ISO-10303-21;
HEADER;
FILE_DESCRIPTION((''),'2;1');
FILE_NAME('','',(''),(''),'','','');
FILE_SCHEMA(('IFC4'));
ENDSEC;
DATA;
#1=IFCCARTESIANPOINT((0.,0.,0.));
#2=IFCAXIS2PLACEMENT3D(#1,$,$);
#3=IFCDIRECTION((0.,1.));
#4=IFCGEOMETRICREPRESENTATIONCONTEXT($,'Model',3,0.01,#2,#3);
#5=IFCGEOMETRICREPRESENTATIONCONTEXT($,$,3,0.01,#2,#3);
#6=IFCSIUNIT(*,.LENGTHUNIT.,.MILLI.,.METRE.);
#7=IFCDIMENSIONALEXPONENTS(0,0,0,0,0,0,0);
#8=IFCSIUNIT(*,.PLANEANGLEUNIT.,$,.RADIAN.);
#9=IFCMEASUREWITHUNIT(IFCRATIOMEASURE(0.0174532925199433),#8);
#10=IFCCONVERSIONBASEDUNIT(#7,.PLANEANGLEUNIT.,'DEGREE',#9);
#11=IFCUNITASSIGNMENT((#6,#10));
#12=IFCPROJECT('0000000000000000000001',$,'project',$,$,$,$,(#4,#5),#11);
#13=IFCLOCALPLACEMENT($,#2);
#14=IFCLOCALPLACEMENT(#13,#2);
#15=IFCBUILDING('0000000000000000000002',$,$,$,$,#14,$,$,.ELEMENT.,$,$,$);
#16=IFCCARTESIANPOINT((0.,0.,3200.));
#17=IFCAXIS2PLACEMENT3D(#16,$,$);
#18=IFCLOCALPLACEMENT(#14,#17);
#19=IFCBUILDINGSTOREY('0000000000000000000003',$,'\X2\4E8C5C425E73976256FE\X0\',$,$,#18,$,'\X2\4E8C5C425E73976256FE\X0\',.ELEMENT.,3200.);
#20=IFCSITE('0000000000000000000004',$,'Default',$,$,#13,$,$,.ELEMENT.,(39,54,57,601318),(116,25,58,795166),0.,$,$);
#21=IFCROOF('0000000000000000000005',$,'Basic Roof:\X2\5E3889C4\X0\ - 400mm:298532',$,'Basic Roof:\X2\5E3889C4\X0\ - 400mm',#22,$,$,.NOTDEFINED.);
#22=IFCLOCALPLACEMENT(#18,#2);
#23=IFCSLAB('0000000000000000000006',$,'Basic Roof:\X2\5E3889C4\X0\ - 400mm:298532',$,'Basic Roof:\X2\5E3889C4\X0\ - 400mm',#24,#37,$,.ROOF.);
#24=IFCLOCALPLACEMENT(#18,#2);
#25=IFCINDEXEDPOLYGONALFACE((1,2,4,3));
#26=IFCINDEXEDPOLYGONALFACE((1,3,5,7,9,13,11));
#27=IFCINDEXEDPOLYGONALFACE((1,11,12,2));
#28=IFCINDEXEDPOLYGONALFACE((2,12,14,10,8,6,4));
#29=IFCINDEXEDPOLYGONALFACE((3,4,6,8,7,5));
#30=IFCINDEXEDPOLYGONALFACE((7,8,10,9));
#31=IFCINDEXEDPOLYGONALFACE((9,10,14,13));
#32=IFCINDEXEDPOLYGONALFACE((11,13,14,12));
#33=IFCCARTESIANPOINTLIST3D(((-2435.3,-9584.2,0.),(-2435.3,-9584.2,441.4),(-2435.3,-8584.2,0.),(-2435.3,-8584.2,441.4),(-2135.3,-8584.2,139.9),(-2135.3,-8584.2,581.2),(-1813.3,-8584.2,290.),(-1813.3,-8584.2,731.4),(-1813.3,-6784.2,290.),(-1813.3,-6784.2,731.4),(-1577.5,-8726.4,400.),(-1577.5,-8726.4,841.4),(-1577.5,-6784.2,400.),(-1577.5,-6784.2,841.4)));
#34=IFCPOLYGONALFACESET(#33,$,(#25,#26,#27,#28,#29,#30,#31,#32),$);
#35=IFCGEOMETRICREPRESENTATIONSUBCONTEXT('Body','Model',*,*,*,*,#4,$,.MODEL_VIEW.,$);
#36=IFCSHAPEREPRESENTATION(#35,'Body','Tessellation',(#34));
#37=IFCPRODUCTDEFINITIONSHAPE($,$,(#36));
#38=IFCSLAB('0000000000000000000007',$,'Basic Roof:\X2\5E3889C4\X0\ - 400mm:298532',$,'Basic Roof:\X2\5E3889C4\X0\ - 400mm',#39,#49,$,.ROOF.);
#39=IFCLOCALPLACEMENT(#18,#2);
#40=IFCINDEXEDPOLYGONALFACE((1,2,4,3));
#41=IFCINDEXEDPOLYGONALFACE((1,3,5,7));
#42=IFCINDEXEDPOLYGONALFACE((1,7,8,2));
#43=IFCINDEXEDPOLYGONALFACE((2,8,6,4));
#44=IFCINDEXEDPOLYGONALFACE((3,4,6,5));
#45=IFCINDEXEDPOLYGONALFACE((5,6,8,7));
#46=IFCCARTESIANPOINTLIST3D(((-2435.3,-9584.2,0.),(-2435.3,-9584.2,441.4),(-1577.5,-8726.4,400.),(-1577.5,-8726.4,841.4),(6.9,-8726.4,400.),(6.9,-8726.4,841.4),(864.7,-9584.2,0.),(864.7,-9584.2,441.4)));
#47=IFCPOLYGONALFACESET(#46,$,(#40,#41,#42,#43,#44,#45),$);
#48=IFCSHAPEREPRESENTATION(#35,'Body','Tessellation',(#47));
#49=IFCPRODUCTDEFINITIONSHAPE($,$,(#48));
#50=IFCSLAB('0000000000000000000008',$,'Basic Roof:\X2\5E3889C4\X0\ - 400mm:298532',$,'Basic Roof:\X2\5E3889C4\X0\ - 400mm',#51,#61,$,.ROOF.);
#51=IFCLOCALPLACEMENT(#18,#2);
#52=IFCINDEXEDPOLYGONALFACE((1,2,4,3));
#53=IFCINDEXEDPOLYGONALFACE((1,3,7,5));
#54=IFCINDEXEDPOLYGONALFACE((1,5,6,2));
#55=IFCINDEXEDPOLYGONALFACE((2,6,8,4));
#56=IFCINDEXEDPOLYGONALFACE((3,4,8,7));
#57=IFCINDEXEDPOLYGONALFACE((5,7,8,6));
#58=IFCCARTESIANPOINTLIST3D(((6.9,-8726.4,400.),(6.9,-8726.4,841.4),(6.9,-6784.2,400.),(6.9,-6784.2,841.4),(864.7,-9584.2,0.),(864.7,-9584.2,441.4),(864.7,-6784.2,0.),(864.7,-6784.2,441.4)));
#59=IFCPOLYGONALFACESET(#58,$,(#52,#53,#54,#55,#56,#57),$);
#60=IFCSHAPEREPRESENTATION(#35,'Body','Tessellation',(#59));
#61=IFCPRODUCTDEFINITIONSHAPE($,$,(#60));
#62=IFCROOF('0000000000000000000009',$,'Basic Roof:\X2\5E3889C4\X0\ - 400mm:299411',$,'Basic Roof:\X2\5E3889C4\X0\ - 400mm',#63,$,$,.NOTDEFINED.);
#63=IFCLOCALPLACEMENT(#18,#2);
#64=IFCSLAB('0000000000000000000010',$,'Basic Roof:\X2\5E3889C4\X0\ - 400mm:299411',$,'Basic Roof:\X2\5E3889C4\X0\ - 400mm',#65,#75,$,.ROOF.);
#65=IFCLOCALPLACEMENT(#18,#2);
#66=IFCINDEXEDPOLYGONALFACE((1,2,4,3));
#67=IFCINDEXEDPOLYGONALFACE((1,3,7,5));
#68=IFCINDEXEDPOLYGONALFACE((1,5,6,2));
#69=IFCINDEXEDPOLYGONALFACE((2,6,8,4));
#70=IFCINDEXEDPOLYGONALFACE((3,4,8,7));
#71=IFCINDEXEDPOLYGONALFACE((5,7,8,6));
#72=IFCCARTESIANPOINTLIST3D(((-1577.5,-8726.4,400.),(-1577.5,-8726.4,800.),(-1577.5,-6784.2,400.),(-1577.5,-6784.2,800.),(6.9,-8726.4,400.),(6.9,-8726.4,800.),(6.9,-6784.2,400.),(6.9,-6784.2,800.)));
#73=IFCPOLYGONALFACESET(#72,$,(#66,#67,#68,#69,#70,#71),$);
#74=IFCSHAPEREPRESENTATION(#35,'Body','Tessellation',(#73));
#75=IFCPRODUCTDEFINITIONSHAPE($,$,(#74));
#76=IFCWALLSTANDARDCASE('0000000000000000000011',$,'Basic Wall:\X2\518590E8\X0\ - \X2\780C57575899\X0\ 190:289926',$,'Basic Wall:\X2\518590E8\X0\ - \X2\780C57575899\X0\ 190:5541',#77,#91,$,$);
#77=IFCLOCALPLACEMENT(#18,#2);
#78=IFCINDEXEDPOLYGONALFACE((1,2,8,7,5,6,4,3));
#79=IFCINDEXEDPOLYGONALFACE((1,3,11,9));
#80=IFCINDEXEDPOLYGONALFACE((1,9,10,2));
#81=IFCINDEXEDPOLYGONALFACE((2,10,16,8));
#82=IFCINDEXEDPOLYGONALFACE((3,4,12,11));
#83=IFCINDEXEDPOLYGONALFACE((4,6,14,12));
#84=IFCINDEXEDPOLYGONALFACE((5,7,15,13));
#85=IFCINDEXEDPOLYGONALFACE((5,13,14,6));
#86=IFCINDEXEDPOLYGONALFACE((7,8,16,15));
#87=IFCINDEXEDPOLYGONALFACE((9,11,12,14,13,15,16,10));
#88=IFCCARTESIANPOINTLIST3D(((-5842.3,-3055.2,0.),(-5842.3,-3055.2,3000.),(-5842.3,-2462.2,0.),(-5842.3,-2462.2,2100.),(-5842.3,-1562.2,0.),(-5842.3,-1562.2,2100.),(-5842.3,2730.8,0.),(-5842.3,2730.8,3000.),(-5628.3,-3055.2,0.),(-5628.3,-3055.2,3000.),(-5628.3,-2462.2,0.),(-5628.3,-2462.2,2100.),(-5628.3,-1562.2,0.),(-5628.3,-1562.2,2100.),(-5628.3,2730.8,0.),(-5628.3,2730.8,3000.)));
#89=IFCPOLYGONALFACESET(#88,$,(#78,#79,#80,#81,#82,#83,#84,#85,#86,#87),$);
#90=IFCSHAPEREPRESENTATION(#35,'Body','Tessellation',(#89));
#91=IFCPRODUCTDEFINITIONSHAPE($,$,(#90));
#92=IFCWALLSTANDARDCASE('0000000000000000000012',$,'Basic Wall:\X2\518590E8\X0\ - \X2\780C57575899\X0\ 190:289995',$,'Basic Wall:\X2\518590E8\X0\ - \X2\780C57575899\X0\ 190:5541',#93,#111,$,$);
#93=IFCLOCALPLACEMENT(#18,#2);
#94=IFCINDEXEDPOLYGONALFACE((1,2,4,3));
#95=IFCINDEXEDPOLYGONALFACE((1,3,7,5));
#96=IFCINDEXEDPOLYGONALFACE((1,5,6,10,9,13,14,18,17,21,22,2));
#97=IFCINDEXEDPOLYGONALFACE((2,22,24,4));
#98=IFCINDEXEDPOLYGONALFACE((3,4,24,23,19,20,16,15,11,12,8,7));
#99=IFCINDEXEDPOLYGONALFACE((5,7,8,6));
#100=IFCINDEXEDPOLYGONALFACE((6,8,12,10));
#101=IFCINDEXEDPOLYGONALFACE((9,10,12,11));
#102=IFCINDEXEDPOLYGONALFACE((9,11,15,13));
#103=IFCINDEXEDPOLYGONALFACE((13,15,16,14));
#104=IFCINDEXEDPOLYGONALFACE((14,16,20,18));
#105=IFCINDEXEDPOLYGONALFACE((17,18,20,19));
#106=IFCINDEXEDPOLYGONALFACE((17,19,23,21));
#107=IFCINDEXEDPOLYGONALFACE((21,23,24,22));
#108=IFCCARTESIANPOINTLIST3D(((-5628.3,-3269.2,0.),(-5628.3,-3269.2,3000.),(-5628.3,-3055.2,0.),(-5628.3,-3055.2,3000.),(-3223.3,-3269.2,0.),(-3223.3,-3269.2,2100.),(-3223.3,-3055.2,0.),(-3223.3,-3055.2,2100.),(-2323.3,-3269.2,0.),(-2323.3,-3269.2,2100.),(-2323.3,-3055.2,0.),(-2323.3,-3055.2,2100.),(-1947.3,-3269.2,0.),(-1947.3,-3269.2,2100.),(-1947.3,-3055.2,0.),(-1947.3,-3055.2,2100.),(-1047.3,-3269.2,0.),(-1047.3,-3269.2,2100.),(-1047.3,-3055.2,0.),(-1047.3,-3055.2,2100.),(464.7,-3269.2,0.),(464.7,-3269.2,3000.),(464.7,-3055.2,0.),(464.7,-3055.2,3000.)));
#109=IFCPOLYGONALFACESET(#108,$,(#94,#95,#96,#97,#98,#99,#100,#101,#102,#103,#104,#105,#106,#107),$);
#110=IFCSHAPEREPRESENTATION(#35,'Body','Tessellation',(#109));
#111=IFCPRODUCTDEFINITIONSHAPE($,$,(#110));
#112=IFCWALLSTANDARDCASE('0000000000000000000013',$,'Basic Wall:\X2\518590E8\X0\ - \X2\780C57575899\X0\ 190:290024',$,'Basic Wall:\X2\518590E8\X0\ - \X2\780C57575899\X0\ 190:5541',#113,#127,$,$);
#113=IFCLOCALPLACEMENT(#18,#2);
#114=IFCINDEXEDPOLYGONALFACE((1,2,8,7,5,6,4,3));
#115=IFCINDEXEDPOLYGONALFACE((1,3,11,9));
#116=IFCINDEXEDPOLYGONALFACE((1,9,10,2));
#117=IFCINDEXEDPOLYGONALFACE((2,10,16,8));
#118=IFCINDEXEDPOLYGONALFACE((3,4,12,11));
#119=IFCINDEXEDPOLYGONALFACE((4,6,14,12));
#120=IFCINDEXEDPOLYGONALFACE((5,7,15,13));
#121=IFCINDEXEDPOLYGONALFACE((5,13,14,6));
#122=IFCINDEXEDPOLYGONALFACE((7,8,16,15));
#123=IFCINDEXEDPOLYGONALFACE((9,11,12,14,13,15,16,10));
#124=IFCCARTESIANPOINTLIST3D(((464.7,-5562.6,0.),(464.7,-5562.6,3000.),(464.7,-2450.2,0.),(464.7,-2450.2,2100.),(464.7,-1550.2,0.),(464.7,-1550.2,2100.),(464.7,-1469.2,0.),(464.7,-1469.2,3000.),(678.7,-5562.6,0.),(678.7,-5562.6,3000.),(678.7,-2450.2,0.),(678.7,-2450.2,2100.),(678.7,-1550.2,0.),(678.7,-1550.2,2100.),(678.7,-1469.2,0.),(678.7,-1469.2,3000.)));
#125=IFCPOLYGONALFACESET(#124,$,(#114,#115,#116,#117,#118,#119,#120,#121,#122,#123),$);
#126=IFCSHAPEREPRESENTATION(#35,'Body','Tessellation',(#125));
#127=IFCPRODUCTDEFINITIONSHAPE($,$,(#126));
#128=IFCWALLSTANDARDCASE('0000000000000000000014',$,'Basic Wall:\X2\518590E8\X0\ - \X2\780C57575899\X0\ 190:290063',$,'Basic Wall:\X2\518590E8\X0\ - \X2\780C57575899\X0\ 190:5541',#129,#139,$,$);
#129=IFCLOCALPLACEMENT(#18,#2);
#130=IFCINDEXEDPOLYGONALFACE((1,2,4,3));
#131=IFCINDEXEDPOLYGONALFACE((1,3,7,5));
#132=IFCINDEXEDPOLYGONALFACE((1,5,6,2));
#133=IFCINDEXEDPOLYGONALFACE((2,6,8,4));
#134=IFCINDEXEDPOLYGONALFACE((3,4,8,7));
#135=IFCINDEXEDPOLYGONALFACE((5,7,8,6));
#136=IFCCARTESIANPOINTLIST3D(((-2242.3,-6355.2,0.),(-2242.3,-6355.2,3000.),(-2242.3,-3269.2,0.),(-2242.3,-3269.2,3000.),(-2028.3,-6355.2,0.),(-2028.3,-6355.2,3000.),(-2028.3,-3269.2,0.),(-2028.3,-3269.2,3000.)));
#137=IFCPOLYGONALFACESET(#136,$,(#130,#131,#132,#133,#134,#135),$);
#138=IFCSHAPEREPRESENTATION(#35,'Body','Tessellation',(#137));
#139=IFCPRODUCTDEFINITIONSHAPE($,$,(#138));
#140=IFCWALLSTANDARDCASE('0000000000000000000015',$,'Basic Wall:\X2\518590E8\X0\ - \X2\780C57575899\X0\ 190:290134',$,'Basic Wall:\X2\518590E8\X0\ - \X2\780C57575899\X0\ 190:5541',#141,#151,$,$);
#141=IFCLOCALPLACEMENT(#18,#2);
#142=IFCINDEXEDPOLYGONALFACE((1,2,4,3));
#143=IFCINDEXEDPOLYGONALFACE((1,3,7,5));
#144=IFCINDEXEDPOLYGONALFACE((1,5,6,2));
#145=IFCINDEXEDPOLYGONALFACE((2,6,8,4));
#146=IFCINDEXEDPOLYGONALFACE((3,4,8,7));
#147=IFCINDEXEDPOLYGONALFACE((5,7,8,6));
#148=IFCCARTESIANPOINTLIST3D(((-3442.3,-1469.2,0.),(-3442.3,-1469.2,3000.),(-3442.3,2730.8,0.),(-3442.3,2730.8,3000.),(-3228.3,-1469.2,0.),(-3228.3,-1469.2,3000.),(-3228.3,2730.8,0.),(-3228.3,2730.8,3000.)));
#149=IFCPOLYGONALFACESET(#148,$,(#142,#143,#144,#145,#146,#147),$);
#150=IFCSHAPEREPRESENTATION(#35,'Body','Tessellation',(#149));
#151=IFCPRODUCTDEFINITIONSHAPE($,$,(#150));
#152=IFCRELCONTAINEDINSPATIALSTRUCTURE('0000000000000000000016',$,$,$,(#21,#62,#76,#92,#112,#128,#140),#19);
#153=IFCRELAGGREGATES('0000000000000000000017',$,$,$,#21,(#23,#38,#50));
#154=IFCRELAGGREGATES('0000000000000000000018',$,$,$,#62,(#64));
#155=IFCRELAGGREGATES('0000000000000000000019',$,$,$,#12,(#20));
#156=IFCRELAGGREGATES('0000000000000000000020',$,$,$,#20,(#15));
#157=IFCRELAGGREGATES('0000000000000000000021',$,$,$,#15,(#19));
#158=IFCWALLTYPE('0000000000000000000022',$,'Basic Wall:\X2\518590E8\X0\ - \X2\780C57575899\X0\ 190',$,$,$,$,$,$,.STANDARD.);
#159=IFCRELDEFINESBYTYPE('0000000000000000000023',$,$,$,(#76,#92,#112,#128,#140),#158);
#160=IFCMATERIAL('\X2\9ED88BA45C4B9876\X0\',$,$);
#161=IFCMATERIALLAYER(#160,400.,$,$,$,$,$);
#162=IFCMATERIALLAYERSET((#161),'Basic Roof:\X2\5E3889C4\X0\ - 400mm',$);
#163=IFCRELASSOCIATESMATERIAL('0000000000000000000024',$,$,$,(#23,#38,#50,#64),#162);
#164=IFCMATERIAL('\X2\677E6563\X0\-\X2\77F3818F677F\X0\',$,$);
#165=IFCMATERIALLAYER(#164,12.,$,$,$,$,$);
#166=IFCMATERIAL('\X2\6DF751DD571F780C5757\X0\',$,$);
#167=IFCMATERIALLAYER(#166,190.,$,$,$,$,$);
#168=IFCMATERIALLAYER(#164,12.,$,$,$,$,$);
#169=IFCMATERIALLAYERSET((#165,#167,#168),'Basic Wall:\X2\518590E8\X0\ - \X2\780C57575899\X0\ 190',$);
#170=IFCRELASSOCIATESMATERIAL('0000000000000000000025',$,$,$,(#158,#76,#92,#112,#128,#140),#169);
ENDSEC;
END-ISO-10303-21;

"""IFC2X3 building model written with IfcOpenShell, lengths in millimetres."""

from ifc_helpers import new_model, entity, si_unit, converted_unit, direction, frame, frame_2d, origin, place, context, subcontext, project, spatial, polyline, rectangle, outline, extrude, material, layer, layer_set, layer_usage, type_object, element, aggregate, save


model = new_model("IFC2X3")

# Units and contexts
model_context = context("Model", 3, precision=0.01, world=origin(), true_north=direction((0.0, 1.0)))
context_of_model = context(None, 3, precision=0.01, world=origin(), true_north=direction((0.0, 1.0)))
body_context = subcontext(model_context, "Body", "Model", "MODEL_VIEW")
ifc_project = project(units=[si_unit("LENGTHUNIT", "METRE", prefix="MILLI"), converted_unit("PLANEANGLEUNIT", "DEGREE", entity("IfcRatioMeasure", 0.0174532925199433), si_unit("PLANEANGLEUNIT", "RADIAN"), dimensions=[0, 0, 0, 0, 0, 0, 0])], contexts=[model_context, context_of_model])

# Site, building, storey
site_placement = place(None, origin())
site = spatial("IfcSite", under=ifc_project, at=site_placement, Name="Default", CompositionType="ELEMENT", RefLatitude=(39, 54, 57, 601318), RefLongitude=(116, 25, 58, 795166), RefElevation=0.0)
building_placement = place(site_placement, origin())
building = spatial("IfcBuilding", under=site, at=building_placement, CompositionType="ELEMENT")
storey_placement = place(building_placement, frame((0.0, 0.0, 3200.0)))
storey = spatial("IfcBuildingStorey", under=building, at=storey_placement, Name="二层平面图", LongName="二层平面图", CompositionType="ELEMENT", Elevation=3200.0)

# Roof, slabs
roof_1_placement = place(storey_placement, frame((-2435.3, -9584.2, 0.0)))
roof_1 = element("IfcRoof", 1, at=roof_1_placement, inside=storey, Name="Basic Roof:常规 - 400mm:298532", ObjectType="Basic Roof:常规 - 400mm", ShapeType="NOTDEFINED")
ifc_material_1 = material(Name="默认屋顶")
ifc_layer_1 = layer(ifc_material_1, 400.0)
ifc_layer_set_1 = layer_set([ifc_layer_1], Name="Basic Roof:常规 - 400mm")
slab_1_placement = place(roof_1_placement, origin())
slab_1 = element("IfcSlab", 2, at=slab_1_placement, material=ifc_layer_set_1, Name="Basic Roof:常规 - 400mm:298532", ObjectType="Basic Roof:常规 - 400mm", PredefinedType="ROOF", context=body_context, shape_type="SweptSolid", body=[
    extrude(outline(polyline([(-473.2, -400.0), (-473.2, -1400.0), (473.2, -542.2), (473.2, 1400.0), (213.1, 1400.0), (213.1, -400.0), (-142.2, -400.0), (-473.2, -400.0)])), frame((428.9, 1400.0, 200.0), z_axis=(-0.422618, 0.0, 0.906308), x_axis=(0.906308, 0.0, 0.422618)), (0.422618, 0.0, 0.906308), 441.4),
])
slab_2_placement = place(roof_1_placement, origin())
slab_2 = element("IfcSlab", 3, at=slab_2_placement, material=ifc_layer_set_1, Name="Basic Roof:常规 - 400mm:298532", ObjectType="Basic Roof:常规 - 400mm", PredefinedType="ROOF", context=body_context, shape_type="SweptSolid", body=[
    extrude(outline(polyline([(1650.0, -473.2), (792.2, 473.2), (-792.2, 473.2), (-1650.0, -473.2), (1650.0, -473.2)])), frame((1650.0, 428.9, 200.0), z_axis=(0.0, -0.422618, 0.906308), x_axis=(1.0, 0.0, 0.0)), (0.0, 0.422618, 0.906308), 441.4),
])
slab_3_placement = place(roof_1_placement, origin())
slab_3 = element("IfcSlab", 4, at=slab_3_placement, material=ifc_layer_set_1, Name="Basic Roof:常规 - 400mm:298532", ObjectType="Basic Roof:常规 - 400mm", PredefinedType="ROOF", context=body_context, shape_type="SweptSolid", body=[
    extrude(outline(polyline([(473.2, 1400.0), (-473.2, 1400.0), (-473.2, -542.2), (473.2, -1400.0), (473.2, 1400.0)])), frame((2871.1, 1400.0, 200.0), z_axis=(0.422618, 0.0, 0.906308), x_axis=(0.906308, 0.0, -0.422618)), (-0.422618, 0.0, 0.906308), 441.4),
])
aggregate(roof_1, [slab_1, slab_2, slab_3])

# Roof, slab
roof_2_placement = place(storey_placement, frame((-1577.5, -8726.4, 400.0)))
roof_2 = element("IfcRoof", 5, at=roof_2_placement, inside=storey, Name="Basic Roof:常规 - 400mm:299411", ObjectType="Basic Roof:常规 - 400mm", ShapeType="NOTDEFINED")
slab_4_placement = place(roof_2_placement, origin())
slab_4 = element("IfcSlab", 6, at=slab_4_placement, material=ifc_layer_set_1, Name="Basic Roof:常规 - 400mm:299411", ObjectType="Basic Roof:常规 - 400mm", PredefinedType="ROOF", context=body_context, shape_type="SweptSolid", body=[
    extrude(rectangle(XDim=1584.4, YDim=1942.2, at=frame_2d((0.0, 0.0), x_axis=(-1.0, 0.0))), frame((792.2, 971.1, 0.0)), (0.0, 0.0, 1.0), 400.0),
])
aggregate(roof_2, [slab_4])

# Wall, opening
ifc_material_2 = material(Name="松散-石膏板")
ifc_layer_2 = layer(ifc_material_2, 12.0)
ifc_material_3 = material(Name="混凝土砌块")
ifc_layer_3 = layer(ifc_material_3, 190.0)
ifc_layer_4 = layer(ifc_material_2, 12.0)
ifc_layer_set_2 = layer_set([ifc_layer_2, ifc_layer_3, ifc_layer_4], Name="Basic Wall:内部 - 砌块墙 190")
ifc_layer_usage_1 = layer_usage(ifc_layer_set_2, "AXIS2", "NEGATIVE", 107.0)
wall_type_1 = type_object("IfcWallType", Name="Basic Wall:内部 - 砌块墙 190", PredefinedType="STANDARD", material=ifc_layer_set_2)
wall_1_placement = place(storey_placement, frame((-5735.3, -3055.2, 0.0), z_axis=(0.0, 0.0, 1.0), x_axis=(0.0, 1.0, 0.0)))
wall_1 = element("IfcWallStandardCase", 7, at=wall_1_placement, inside=storey, type_object=wall_type_1, material=ifc_layer_usage_1, Name="Basic Wall:内部 - 砌块墙 190:289926", ObjectType="Basic Wall:内部 - 砌块墙 190:5541", context=body_context, shape_type="SweptSolid", body=[
    extrude(rectangle(XDim=5786.0, YDim=214.0, at=frame_2d((2893.0, 0.0), x_axis=(-1.0, 0.0))), origin(), (0.0, 0.0, 1.0), 3000.0),
])
opening_1_placement = place(wall_1_placement, frame((593.0, -107.0, 0.0)))
element("IfcOpeningElement", 8, at=opening_1_placement, cuts=wall_1, ObjectType="Opening", context=body_context, shape_type="SweptSolid", body=[
    extrude(rectangle(XDim=900.0, YDim=2100.0, at=frame_2d((1050.0, 450.0), x_axis=(0.0, -1.0))), frame((0.0, 0.0, 0.0), z_axis=(0.0, 1.0, 0.0), x_axis=(0.0, 0.0, 1.0)), (0.0, 0.0, 1.0), 214.0),
])

# Wall, openings
ifc_layer_usage_2 = layer_usage(ifc_layer_set_2, "AXIS2", "NEGATIVE", 107.0)
wall_2_placement = place(storey_placement, frame((-5628.3, -3162.2, 0.0)))
wall_2 = element("IfcWallStandardCase", 9, at=wall_2_placement, inside=storey, type_object=wall_type_1, material=ifc_layer_usage_2, Name="Basic Wall:内部 - 砌块墙 190:289995", ObjectType="Basic Wall:内部 - 砌块墙 190:5541", context=body_context, shape_type="SweptSolid", body=[
    extrude(rectangle(XDim=6093.0, YDim=214.0, at=frame_2d((3046.5, 0.0), x_axis=(-1.0, 0.0))), origin(), (0.0, 0.0, 1.0), 3000.0),
])
opening_2_placement = place(wall_2_placement, frame((4581.0, 107.0, 0.0)))
element("IfcOpeningElement", 10, at=opening_2_placement, cuts=wall_2, ObjectType="Opening", context=body_context, shape_type="SweptSolid", body=[
    extrude(rectangle(XDim=900.0, YDim=2100.0, at=frame_2d((1050.0, 450.0), x_axis=(0.0, -1.0))), frame((0.0, 0.0, 0.0), z_axis=(0.0, -1.0, 0.0), x_axis=(0.0, 0.0, 1.0)), (0.0, 0.0, 1.0), 214.0),
])
opening_3_placement = place(wall_2_placement, frame((3305.0, 107.0, 0.0)))
element("IfcOpeningElement", 11, at=opening_3_placement, cuts=wall_2, ObjectType="Opening", context=body_context, shape_type="SweptSolid", body=[
    extrude(rectangle(XDim=900.0, YDim=2100.0, at=frame_2d((1050.0, 450.0), x_axis=(0.0, 1.0))), frame((0.0, 0.0, 0.0), z_axis=(0.0, -1.0, 0.0), x_axis=(0.0, 0.0, 1.0)), (0.0, 0.0, 1.0), 214.0),
])

# Wall, opening
ifc_layer_usage_3 = layer_usage(ifc_layer_set_2, "AXIS2", "NEGATIVE", 107.0)
wall_3_placement = place(storey_placement, frame((571.7, -1469.2, 0.0), z_axis=(0.0, 0.0, 1.0), x_axis=(0.0, -1.0, 0.0)))
wall_3 = element("IfcWallStandardCase", 12, at=wall_3_placement, inside=storey, type_object=wall_type_1, material=ifc_layer_usage_3, Name="Basic Wall:内部 - 砌块墙 190:290024", ObjectType="Basic Wall:内部 - 砌块墙 190:5541", context=body_context, shape_type="SweptSolid", body=[
    extrude(rectangle(XDim=4093.4, YDim=214.0, at=frame_2d((2046.7, 0.0), x_axis=(-1.0, 0.0))), origin(), (0.0, 0.0, 1.0), 3000.0),
])
opening_4_placement = place(wall_3_placement, frame((81.0, -107.0, 0.0)))
element("IfcOpeningElement", 13, at=opening_4_placement, cuts=wall_3, ObjectType="Opening", context=body_context, shape_type="SweptSolid", body=[
    extrude(rectangle(XDim=900.0, YDim=2100.0, at=frame_2d((1050.0, 450.0), x_axis=(0.0, 1.0))), frame((0.0, 0.0, 0.0), z_axis=(0.0, 1.0, 0.0), x_axis=(0.0, 0.0, 1.0)), (0.0, 0.0, 1.0), 214.0),
])

# Walls
ifc_layer_usage_4 = layer_usage(ifc_layer_set_2, "AXIS2", "NEGATIVE", 107.0)
wall_4_placement = place(storey_placement, frame((-2135.3, -3269.2, 0.0), z_axis=(0.0, 0.0, 1.0), x_axis=(0.0, -1.0, 0.0)))
element("IfcWallStandardCase", 14, at=wall_4_placement, inside=storey, type_object=wall_type_1, material=ifc_layer_usage_4, Name="Basic Wall:内部 - 砌块墙 190:290063", ObjectType="Basic Wall:内部 - 砌块墙 190:5541", context=body_context, shape_type="SweptSolid", body=[
    extrude(rectangle(XDim=3086.0, YDim=214.0, at=frame_2d((1543.0, 0.0), x_axis=(-1.0, 0.0))), origin(), (0.0, 0.0, 1.0), 3000.0),
])
ifc_layer_usage_5 = layer_usage(ifc_layer_set_2, "AXIS2", "NEGATIVE", 107.0)
wall_5_placement = place(storey_placement, frame((-3335.3, 2730.8, 0.0), z_axis=(0.0, 0.0, 1.0), x_axis=(0.0, -1.0, 0.0)))
element("IfcWallStandardCase", 15, at=wall_5_placement, inside=storey, type_object=wall_type_1, material=ifc_layer_usage_5, Name="Basic Wall:内部 - 砌块墙 190:290134", ObjectType="Basic Wall:内部 - 砌块墙 190:5541", context=body_context, shape_type="SweptSolid", body=[
    extrude(rectangle(XDim=4200.0, YDim=214.0, at=frame_2d((2100.0, 0.0), x_axis=(-1.0, 0.0))), origin(), (0.0, 0.0, 1.0), 3000.0),
])

save(model, "model.ifc")
